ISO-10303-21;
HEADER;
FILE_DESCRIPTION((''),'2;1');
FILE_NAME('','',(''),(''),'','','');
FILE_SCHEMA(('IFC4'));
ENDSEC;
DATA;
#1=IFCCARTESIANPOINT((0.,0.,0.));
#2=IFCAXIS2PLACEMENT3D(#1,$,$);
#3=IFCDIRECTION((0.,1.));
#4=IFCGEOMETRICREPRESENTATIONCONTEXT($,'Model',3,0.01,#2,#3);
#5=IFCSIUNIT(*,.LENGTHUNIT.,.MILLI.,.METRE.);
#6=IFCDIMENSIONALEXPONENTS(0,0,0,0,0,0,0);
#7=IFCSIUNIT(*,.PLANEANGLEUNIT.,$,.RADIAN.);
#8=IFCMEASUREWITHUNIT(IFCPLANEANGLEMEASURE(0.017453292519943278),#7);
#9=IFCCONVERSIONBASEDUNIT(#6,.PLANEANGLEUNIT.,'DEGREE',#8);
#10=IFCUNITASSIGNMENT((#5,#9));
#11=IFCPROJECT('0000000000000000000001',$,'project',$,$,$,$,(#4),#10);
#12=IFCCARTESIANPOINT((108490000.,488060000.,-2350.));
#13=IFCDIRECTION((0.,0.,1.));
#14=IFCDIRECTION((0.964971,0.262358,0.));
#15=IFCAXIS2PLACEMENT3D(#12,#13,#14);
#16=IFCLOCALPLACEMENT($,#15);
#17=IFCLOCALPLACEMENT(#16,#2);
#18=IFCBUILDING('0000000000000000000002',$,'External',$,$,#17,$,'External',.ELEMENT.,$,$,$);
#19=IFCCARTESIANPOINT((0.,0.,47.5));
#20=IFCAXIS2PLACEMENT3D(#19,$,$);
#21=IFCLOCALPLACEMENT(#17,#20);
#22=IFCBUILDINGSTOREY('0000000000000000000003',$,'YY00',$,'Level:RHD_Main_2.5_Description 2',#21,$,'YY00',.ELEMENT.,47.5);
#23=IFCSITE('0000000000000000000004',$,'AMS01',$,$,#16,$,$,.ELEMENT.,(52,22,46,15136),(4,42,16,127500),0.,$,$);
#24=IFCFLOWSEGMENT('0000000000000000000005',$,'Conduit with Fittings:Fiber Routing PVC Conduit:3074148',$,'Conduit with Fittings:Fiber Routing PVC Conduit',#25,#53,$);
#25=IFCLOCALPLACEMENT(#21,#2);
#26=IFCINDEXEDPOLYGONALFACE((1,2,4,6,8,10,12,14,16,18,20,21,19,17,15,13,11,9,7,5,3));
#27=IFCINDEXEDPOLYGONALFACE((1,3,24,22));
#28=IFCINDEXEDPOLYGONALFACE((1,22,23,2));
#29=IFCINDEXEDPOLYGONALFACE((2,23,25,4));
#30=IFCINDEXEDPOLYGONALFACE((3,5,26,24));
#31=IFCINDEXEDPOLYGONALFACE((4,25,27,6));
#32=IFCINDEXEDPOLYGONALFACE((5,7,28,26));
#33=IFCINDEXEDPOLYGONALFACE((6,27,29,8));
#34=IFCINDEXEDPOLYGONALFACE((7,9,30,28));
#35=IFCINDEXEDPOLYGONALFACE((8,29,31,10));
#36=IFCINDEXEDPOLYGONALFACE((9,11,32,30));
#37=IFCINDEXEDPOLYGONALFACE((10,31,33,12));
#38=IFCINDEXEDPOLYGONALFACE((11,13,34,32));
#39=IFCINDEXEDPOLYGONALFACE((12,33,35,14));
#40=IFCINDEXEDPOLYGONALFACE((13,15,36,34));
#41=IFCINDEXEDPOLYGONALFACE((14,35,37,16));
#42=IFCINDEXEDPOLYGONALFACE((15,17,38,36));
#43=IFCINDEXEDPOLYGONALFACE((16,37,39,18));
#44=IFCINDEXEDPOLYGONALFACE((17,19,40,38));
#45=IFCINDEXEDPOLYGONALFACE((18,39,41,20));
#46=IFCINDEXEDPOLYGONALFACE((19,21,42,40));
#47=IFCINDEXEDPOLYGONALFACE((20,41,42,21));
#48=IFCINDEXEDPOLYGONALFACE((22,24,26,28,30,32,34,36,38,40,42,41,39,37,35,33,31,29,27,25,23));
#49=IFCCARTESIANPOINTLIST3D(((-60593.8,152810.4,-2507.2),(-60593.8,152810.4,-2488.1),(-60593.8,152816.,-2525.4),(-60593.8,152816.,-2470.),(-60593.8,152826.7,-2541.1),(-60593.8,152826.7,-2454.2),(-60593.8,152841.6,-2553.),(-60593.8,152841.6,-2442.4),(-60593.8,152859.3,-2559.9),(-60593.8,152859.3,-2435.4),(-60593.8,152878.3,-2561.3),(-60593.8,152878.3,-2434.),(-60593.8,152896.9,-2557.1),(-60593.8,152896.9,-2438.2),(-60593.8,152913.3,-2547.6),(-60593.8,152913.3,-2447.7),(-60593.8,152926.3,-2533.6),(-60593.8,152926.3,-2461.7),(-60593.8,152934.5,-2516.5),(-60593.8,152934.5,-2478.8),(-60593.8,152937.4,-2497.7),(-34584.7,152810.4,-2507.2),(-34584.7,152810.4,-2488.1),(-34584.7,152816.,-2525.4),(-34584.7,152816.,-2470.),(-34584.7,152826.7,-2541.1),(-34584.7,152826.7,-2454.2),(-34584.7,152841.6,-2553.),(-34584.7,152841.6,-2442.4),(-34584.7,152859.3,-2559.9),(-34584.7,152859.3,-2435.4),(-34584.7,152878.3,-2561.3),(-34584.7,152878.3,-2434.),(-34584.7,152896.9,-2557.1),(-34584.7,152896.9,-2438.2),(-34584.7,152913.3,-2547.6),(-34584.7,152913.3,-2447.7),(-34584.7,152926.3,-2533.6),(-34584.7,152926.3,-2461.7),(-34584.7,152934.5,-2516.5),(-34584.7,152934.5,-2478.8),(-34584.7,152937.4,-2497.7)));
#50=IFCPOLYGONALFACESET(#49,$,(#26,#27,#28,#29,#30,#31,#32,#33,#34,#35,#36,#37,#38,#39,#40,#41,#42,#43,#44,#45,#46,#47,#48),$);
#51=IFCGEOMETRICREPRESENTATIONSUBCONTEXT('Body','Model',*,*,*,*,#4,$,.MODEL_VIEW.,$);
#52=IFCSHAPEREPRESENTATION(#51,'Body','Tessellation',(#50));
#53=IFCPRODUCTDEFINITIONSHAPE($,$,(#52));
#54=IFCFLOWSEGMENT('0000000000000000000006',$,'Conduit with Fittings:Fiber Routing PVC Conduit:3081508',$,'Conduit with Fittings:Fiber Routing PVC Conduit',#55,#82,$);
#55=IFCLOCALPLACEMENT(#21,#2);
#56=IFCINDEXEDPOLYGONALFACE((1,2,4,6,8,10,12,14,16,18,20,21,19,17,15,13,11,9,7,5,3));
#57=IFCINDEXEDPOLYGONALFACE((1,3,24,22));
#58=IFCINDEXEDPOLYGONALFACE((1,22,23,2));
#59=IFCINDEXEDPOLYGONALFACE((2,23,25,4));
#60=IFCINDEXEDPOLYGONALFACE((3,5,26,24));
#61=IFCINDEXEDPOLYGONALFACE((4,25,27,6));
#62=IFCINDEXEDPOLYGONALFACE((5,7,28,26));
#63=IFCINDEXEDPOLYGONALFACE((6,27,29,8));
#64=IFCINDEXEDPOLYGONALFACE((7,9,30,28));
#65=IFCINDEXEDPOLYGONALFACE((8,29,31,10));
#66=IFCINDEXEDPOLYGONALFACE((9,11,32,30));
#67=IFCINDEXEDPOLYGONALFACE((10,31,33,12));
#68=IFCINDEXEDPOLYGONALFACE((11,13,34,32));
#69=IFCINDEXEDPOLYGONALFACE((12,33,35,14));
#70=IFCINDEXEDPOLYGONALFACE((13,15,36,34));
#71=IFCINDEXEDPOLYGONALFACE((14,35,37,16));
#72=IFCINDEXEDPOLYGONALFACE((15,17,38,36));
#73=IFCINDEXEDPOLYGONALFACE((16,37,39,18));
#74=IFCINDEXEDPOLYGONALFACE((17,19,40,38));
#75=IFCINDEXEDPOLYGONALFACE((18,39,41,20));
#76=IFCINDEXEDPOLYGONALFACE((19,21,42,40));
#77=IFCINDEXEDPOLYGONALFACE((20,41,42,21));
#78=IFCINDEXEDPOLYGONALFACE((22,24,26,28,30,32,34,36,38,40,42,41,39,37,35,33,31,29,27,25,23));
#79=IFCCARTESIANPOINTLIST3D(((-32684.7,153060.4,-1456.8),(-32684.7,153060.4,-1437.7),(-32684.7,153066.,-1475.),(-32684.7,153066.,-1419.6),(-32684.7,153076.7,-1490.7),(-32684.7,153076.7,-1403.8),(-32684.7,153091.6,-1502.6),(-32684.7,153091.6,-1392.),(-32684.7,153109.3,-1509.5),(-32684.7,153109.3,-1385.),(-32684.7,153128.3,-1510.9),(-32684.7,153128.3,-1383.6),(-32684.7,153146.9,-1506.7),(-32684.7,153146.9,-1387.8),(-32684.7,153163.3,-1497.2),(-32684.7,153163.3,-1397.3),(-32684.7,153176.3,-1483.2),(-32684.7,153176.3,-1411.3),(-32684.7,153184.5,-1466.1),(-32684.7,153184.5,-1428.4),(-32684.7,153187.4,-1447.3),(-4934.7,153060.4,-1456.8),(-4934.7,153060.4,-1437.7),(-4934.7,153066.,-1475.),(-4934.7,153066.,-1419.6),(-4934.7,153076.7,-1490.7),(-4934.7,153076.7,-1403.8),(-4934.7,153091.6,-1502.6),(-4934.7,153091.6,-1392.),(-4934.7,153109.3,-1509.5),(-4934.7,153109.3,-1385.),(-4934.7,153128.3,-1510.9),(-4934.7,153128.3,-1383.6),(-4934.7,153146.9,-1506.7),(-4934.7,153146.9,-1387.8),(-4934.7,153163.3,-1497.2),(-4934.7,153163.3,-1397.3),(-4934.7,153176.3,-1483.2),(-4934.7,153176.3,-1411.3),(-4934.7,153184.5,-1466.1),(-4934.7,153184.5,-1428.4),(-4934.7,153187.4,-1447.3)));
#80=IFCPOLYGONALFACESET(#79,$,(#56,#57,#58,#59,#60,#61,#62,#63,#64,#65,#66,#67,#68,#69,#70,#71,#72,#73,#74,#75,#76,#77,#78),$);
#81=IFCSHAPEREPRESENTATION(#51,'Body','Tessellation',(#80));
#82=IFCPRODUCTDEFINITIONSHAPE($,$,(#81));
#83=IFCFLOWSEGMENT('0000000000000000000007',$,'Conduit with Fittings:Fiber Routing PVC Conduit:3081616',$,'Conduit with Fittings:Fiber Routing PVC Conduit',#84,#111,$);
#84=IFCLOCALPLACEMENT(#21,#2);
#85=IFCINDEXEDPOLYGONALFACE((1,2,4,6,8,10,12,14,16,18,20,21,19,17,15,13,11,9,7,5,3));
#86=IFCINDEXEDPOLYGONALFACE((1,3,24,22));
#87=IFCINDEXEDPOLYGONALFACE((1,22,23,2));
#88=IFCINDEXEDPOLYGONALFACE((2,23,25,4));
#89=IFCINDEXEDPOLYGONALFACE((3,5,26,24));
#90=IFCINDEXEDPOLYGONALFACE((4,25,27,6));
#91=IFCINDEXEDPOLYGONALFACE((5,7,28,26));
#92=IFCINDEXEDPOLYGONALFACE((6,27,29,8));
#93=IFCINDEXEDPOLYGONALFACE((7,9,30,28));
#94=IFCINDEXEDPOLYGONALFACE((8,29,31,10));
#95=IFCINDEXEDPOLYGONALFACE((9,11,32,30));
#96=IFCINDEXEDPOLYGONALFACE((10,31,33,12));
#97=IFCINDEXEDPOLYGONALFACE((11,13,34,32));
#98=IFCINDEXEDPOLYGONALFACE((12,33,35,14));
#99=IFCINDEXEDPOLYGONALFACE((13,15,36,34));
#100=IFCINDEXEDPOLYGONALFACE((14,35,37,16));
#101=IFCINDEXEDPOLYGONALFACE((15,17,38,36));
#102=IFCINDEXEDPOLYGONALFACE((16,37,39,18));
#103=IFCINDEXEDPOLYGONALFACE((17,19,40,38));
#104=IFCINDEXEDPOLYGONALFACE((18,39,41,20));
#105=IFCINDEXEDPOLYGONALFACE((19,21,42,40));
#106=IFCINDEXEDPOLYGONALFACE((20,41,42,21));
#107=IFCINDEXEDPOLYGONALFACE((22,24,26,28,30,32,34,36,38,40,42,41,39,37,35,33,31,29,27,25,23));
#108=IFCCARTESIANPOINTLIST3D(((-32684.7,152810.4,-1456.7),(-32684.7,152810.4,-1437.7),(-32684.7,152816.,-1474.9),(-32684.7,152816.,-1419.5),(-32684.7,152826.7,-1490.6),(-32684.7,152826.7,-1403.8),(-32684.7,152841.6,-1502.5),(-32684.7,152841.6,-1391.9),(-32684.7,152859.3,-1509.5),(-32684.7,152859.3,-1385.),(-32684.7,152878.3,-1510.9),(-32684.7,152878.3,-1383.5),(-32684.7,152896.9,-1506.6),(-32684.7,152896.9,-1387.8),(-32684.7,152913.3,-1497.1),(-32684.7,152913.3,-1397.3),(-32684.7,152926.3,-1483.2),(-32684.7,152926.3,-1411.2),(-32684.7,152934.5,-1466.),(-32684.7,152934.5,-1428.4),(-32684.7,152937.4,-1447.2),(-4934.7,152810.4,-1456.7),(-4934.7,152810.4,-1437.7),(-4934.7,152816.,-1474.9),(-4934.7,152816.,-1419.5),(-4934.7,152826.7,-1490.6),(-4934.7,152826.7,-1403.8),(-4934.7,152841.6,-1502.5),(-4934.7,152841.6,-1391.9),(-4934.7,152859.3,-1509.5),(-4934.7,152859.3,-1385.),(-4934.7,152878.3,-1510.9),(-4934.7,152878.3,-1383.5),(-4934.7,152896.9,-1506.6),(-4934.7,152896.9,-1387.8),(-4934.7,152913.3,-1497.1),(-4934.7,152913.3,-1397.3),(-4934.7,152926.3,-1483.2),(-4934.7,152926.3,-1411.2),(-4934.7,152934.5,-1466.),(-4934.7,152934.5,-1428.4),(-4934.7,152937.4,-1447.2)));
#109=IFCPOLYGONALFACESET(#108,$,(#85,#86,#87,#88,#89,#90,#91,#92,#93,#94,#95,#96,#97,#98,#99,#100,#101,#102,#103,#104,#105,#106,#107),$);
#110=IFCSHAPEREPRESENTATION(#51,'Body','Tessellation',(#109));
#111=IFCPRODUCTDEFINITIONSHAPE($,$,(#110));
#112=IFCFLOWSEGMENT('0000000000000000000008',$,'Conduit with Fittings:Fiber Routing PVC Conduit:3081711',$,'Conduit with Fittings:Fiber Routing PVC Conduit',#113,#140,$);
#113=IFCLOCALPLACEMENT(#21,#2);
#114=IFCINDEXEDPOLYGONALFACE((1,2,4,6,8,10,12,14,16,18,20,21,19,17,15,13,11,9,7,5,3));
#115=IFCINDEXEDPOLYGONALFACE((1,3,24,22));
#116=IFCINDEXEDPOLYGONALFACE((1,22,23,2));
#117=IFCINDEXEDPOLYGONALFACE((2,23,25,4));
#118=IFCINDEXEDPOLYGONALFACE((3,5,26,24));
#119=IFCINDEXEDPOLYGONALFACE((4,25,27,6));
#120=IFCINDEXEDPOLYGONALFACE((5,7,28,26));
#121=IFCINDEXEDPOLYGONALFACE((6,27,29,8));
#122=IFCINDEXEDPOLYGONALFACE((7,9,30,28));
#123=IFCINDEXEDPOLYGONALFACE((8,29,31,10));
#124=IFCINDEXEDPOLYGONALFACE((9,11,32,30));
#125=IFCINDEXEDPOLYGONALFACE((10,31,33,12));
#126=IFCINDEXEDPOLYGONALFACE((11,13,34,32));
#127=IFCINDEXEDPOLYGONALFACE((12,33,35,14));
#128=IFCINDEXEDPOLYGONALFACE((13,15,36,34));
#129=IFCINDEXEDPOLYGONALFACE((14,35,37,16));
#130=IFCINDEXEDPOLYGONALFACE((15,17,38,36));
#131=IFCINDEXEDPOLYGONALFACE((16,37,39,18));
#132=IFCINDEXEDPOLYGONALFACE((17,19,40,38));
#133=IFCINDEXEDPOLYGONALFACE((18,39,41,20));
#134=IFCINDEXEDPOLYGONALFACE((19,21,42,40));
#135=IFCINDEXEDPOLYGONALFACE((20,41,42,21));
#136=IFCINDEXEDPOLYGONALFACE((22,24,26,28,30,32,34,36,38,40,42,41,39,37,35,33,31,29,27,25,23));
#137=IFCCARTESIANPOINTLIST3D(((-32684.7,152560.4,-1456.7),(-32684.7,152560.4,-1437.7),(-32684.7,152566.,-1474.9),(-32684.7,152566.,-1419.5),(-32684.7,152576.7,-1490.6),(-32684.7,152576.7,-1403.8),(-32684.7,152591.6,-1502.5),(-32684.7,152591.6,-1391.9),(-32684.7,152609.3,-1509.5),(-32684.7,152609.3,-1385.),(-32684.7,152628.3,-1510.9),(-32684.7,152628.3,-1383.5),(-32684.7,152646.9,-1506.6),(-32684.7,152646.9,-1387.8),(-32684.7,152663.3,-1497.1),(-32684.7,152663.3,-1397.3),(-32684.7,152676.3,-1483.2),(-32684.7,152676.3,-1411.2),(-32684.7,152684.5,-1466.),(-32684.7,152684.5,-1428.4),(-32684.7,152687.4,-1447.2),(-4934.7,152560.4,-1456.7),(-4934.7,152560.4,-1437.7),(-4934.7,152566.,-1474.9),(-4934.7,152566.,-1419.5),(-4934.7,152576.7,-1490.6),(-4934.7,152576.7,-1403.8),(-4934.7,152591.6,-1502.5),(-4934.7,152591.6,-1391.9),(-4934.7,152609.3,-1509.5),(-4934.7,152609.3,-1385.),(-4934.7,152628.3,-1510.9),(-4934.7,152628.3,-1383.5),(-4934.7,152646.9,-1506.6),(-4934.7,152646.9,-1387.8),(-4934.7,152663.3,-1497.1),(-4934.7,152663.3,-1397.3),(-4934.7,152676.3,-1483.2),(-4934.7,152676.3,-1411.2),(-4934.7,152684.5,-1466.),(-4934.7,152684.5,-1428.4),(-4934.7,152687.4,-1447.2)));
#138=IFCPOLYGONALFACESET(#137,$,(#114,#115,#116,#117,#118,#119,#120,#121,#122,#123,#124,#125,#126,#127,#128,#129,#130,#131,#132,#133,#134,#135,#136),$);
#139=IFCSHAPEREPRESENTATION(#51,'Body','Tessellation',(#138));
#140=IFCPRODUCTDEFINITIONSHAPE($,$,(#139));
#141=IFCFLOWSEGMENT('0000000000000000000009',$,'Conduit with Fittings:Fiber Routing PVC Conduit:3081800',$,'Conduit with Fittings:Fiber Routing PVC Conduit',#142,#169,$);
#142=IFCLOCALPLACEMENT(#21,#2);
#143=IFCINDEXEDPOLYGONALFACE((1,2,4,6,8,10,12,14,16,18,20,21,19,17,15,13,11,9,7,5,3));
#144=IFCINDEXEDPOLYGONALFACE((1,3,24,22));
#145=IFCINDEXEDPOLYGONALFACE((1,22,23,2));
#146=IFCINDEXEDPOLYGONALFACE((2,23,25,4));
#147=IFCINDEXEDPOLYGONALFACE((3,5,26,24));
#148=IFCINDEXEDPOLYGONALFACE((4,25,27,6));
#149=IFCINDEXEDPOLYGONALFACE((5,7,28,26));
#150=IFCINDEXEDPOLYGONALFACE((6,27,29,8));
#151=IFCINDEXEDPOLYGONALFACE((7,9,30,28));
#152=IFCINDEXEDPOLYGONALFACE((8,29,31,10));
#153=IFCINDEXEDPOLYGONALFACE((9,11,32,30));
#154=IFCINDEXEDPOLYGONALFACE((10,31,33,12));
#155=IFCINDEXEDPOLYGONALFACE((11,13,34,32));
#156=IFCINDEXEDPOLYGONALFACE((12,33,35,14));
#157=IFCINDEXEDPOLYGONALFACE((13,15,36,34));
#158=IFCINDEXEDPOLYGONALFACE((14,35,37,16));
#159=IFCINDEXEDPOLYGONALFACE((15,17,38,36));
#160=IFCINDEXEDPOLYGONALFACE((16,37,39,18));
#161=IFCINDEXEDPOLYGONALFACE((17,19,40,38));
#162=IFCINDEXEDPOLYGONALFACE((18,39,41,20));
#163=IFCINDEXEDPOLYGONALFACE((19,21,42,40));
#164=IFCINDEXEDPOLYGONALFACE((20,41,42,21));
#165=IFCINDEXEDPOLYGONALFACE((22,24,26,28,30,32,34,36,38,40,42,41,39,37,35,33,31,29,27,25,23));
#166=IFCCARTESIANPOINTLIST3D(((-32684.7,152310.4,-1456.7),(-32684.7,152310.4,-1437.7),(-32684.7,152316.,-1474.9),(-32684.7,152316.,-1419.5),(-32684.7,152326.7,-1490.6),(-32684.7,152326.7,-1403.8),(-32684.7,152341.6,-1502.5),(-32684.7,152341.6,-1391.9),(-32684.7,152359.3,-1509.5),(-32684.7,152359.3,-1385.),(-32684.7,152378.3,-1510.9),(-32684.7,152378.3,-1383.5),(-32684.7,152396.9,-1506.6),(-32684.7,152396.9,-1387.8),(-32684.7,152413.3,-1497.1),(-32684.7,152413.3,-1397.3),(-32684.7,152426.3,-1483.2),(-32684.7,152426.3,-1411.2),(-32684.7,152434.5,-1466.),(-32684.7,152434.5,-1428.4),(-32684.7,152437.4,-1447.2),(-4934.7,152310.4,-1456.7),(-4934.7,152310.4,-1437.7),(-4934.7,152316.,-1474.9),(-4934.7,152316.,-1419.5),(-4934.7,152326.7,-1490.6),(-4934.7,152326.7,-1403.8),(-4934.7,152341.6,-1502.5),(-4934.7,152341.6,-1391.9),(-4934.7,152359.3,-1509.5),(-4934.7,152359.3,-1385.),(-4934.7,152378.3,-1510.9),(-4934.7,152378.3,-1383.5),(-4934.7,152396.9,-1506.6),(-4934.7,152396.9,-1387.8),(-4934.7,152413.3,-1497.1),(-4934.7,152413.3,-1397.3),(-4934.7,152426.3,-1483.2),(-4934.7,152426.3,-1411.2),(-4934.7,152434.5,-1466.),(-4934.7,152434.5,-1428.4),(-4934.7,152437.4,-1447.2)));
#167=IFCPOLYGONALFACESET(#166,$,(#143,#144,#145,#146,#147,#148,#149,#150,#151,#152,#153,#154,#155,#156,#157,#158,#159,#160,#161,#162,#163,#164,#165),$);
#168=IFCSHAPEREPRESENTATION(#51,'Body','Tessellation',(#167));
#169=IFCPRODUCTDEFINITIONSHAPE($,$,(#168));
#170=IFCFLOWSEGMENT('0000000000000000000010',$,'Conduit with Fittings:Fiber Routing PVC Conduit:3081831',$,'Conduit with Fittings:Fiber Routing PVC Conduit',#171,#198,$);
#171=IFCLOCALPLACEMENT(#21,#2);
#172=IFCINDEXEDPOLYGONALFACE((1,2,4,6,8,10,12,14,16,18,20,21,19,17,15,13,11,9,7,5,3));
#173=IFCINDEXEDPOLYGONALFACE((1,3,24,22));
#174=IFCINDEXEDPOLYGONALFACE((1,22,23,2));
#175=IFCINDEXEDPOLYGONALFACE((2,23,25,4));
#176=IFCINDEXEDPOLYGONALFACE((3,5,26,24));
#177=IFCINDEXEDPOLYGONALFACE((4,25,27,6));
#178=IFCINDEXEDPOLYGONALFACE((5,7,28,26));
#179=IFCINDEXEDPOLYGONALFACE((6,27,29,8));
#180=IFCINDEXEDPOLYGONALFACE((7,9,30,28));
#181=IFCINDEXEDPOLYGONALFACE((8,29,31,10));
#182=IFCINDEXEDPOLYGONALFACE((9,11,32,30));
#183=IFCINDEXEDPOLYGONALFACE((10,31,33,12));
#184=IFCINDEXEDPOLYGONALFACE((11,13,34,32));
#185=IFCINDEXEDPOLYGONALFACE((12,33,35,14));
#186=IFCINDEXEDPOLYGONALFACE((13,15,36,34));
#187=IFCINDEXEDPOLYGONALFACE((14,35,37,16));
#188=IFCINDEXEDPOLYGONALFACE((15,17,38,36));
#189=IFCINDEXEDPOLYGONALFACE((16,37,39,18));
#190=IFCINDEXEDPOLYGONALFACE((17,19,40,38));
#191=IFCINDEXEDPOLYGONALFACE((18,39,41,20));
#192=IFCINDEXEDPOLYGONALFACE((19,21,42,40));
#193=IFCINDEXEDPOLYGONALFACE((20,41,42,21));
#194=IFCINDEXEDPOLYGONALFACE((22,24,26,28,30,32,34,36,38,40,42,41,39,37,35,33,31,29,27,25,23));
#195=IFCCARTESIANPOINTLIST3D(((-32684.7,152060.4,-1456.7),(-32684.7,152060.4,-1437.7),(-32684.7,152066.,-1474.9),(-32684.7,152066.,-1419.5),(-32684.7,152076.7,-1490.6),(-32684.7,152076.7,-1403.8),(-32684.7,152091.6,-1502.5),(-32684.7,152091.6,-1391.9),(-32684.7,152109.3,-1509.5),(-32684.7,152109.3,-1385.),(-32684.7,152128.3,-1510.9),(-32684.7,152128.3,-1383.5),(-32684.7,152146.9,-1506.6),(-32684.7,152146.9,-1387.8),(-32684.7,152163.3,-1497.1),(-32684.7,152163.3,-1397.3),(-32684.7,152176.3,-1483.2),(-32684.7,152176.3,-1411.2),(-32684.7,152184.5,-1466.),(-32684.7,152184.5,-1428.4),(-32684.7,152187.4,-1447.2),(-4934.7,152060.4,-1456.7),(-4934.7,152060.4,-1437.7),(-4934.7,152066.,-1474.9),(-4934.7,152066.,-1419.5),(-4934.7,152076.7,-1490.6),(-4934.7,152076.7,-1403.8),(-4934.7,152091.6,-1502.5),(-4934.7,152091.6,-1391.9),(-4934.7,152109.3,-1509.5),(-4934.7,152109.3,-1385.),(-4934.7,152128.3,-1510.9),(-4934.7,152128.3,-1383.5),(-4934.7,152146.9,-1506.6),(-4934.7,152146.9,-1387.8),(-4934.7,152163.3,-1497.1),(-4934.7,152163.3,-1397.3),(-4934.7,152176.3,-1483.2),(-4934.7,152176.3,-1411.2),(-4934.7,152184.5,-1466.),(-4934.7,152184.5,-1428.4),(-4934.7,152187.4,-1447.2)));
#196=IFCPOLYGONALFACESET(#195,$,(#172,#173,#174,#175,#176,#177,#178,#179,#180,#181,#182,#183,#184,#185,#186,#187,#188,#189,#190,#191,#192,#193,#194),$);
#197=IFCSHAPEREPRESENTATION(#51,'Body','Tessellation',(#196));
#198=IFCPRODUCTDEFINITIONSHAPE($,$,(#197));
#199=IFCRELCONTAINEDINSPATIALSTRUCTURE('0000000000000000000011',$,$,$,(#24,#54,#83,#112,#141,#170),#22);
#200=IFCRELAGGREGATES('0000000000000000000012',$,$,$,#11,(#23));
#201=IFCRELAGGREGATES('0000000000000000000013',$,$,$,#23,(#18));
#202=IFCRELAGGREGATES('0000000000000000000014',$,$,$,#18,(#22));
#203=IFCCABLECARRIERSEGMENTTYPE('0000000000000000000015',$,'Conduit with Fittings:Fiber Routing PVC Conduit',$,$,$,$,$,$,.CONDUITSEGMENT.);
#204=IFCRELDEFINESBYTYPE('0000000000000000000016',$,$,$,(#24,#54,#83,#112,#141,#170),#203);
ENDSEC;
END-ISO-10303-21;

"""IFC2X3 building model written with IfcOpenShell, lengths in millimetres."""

from ifc_helpers import new_model, entity, si_unit, converted_unit, direction, frame, frame_2d, origin, place, context, subcontext, project, spatial, circle, extrude, type_object, element, save


model = new_model("IFC2X3")

# Units and contexts
model_context = context("Model", 3, precision=0.01, world=origin(), true_north=direction((0.0, 1.0)))
body_context = subcontext(model_context, "Body", "Model", "MODEL_VIEW")
ifc_project = project(units=[si_unit("LENGTHUNIT", "METRE", prefix="MILLI"), converted_unit("PLANEANGLEUNIT", "DEGREE", entity("IfcPlaneAngleMeasure", 0.017453292519943278), si_unit("PLANEANGLEUNIT", "RADIAN"), dimensions=[0, 0, 0, 0, 0, 0, 0])], contexts=[model_context])

# Site, building, storey
site_placement = place(None, frame((108490000.0, 488060000.0, -2350.0), z_axis=(0.0, 0.0, 1.0), x_axis=(0.964971, 0.262358, 0.0)))
site = spatial("IfcSite", under=ifc_project, at=site_placement, Name="AMS01", CompositionType="ELEMENT", RefLatitude=(52, 22, 46, 15136), RefLongitude=(4, 42, 16, 127500), RefElevation=0.0)
building_placement = place(site_placement, origin())
building = spatial("IfcBuilding", under=site, at=building_placement, Name="External", LongName="External", CompositionType="ELEMENT")
storey_placement = place(building_placement, frame((0.0, 0.0, 47.5)))
storey = spatial("IfcBuildingStorey", under=building, at=storey_placement, Name="YY00", ObjectType="Level:RHD_Main_2.5_Description 2", LongName="YY00", CompositionType="ELEMENT", Elevation=47.5)

# Flow segments
cable_carrier_segment_type = type_object("IfcCableCarrierSegmentType", Name="Conduit with Fittings:Fiber Routing PVC Conduit", PredefinedType="CONDUITSEGMENT")
flow_segment_1_placement = place(storey_placement, origin())
element("IfcFlowSegment", 1, at=flow_segment_1_placement, inside=storey, type_object=cable_carrier_segment_type, Name="Conduit with Fittings:Fiber Routing PVC Conduit:3074148", ObjectType="Conduit with Fittings:Fiber Routing PVC Conduit", context=body_context, shape_type="SweptSolid", body=[
    extrude(circle(Radius=63.9, at=frame_2d((0.0, 0.0), x_axis=(1.0, 0.0))), frame((-60593.8, 152873.5, -2497.7), z_axis=(1.0, 0.0, 0.0), x_axis=(0.0, 1.0, 0.0)), (0.0, 0.0, 1.0), 26009.1),
])
flow_segment_2_placement = place(storey_placement, origin())
element("IfcFlowSegment", 2, at=flow_segment_2_placement, inside=storey, type_object=cable_carrier_segment_type, Name="Conduit with Fittings:Fiber Routing PVC Conduit:3081508", ObjectType="Conduit with Fittings:Fiber Routing PVC Conduit", context=body_context, shape_type="SweptSolid", body=[
    extrude(circle(Radius=63.9, at=frame_2d((0.0, 0.0), x_axis=(1.0, 0.0))), frame((-32684.7, 153123.5, -1447.3), z_axis=(1.0, 0.0, 0.0), x_axis=(0.0, 1.0, 0.0)), (0.0, 0.0, 1.0), 27750.0),
])
flow_segment_3_placement = place(storey_placement, origin())
element("IfcFlowSegment", 3, at=flow_segment_3_placement, inside=storey, type_object=cable_carrier_segment_type, Name="Conduit with Fittings:Fiber Routing PVC Conduit:3081616", ObjectType="Conduit with Fittings:Fiber Routing PVC Conduit", context=body_context, shape_type="SweptSolid", body=[
    extrude(circle(Radius=63.9, at=frame_2d((0.0, 0.0), x_axis=(1.0, 0.0))), frame((-32684.7, 152873.5, -1447.2), z_axis=(1.0, 0.0, 0.0), x_axis=(0.0, 1.0, 0.0)), (0.0, 0.0, 1.0), 27750.0),
])
flow_segment_4_placement = place(storey_placement, origin())
element("IfcFlowSegment", 4, at=flow_segment_4_placement, inside=storey, type_object=cable_carrier_segment_type, Name="Conduit with Fittings:Fiber Routing PVC Conduit:3081711", ObjectType="Conduit with Fittings:Fiber Routing PVC Conduit", context=body_context, shape_type="SweptSolid", body=[
    extrude(circle(Radius=63.9, at=frame_2d((0.0, 0.0), x_axis=(1.0, 0.0))), frame((-32684.7, 152623.5, -1447.2), z_axis=(1.0, 0.0, 0.0), x_axis=(0.0, 1.0, 0.0)), (0.0, 0.0, 1.0), 27750.0),
])
flow_segment_5_placement = place(storey_placement, origin())
element("IfcFlowSegment", 5, at=flow_segment_5_placement, inside=storey, type_object=cable_carrier_segment_type, Name="Conduit with Fittings:Fiber Routing PVC Conduit:3081800", ObjectType="Conduit with Fittings:Fiber Routing PVC Conduit", context=body_context, shape_type="SweptSolid", body=[
    extrude(circle(Radius=63.9, at=frame_2d((0.0, 0.0), x_axis=(1.0, 0.0))), frame((-32684.7, 152373.5, -1447.2), z_axis=(1.0, 0.0, 0.0), x_axis=(0.0, 1.0, 0.0)), (0.0, 0.0, 1.0), 27750.0),
])
flow_segment_6_placement = place(storey_placement, origin())
element("IfcFlowSegment", 6, at=flow_segment_6_placement, inside=storey, type_object=cable_carrier_segment_type, Name="Conduit with Fittings:Fiber Routing PVC Conduit:3081831", ObjectType="Conduit with Fittings:Fiber Routing PVC Conduit", context=body_context, shape_type="SweptSolid", body=[
    extrude(circle(Radius=63.9, at=frame_2d((0.0, 0.0), x_axis=(1.0, 0.0))), frame((-32684.7, 152123.5, -1447.2), z_axis=(1.0, 0.0, 0.0), x_axis=(0.0, 1.0, 0.0)), (0.0, 0.0, 1.0), 27750.0),
])

save(model, "model.ifc")
